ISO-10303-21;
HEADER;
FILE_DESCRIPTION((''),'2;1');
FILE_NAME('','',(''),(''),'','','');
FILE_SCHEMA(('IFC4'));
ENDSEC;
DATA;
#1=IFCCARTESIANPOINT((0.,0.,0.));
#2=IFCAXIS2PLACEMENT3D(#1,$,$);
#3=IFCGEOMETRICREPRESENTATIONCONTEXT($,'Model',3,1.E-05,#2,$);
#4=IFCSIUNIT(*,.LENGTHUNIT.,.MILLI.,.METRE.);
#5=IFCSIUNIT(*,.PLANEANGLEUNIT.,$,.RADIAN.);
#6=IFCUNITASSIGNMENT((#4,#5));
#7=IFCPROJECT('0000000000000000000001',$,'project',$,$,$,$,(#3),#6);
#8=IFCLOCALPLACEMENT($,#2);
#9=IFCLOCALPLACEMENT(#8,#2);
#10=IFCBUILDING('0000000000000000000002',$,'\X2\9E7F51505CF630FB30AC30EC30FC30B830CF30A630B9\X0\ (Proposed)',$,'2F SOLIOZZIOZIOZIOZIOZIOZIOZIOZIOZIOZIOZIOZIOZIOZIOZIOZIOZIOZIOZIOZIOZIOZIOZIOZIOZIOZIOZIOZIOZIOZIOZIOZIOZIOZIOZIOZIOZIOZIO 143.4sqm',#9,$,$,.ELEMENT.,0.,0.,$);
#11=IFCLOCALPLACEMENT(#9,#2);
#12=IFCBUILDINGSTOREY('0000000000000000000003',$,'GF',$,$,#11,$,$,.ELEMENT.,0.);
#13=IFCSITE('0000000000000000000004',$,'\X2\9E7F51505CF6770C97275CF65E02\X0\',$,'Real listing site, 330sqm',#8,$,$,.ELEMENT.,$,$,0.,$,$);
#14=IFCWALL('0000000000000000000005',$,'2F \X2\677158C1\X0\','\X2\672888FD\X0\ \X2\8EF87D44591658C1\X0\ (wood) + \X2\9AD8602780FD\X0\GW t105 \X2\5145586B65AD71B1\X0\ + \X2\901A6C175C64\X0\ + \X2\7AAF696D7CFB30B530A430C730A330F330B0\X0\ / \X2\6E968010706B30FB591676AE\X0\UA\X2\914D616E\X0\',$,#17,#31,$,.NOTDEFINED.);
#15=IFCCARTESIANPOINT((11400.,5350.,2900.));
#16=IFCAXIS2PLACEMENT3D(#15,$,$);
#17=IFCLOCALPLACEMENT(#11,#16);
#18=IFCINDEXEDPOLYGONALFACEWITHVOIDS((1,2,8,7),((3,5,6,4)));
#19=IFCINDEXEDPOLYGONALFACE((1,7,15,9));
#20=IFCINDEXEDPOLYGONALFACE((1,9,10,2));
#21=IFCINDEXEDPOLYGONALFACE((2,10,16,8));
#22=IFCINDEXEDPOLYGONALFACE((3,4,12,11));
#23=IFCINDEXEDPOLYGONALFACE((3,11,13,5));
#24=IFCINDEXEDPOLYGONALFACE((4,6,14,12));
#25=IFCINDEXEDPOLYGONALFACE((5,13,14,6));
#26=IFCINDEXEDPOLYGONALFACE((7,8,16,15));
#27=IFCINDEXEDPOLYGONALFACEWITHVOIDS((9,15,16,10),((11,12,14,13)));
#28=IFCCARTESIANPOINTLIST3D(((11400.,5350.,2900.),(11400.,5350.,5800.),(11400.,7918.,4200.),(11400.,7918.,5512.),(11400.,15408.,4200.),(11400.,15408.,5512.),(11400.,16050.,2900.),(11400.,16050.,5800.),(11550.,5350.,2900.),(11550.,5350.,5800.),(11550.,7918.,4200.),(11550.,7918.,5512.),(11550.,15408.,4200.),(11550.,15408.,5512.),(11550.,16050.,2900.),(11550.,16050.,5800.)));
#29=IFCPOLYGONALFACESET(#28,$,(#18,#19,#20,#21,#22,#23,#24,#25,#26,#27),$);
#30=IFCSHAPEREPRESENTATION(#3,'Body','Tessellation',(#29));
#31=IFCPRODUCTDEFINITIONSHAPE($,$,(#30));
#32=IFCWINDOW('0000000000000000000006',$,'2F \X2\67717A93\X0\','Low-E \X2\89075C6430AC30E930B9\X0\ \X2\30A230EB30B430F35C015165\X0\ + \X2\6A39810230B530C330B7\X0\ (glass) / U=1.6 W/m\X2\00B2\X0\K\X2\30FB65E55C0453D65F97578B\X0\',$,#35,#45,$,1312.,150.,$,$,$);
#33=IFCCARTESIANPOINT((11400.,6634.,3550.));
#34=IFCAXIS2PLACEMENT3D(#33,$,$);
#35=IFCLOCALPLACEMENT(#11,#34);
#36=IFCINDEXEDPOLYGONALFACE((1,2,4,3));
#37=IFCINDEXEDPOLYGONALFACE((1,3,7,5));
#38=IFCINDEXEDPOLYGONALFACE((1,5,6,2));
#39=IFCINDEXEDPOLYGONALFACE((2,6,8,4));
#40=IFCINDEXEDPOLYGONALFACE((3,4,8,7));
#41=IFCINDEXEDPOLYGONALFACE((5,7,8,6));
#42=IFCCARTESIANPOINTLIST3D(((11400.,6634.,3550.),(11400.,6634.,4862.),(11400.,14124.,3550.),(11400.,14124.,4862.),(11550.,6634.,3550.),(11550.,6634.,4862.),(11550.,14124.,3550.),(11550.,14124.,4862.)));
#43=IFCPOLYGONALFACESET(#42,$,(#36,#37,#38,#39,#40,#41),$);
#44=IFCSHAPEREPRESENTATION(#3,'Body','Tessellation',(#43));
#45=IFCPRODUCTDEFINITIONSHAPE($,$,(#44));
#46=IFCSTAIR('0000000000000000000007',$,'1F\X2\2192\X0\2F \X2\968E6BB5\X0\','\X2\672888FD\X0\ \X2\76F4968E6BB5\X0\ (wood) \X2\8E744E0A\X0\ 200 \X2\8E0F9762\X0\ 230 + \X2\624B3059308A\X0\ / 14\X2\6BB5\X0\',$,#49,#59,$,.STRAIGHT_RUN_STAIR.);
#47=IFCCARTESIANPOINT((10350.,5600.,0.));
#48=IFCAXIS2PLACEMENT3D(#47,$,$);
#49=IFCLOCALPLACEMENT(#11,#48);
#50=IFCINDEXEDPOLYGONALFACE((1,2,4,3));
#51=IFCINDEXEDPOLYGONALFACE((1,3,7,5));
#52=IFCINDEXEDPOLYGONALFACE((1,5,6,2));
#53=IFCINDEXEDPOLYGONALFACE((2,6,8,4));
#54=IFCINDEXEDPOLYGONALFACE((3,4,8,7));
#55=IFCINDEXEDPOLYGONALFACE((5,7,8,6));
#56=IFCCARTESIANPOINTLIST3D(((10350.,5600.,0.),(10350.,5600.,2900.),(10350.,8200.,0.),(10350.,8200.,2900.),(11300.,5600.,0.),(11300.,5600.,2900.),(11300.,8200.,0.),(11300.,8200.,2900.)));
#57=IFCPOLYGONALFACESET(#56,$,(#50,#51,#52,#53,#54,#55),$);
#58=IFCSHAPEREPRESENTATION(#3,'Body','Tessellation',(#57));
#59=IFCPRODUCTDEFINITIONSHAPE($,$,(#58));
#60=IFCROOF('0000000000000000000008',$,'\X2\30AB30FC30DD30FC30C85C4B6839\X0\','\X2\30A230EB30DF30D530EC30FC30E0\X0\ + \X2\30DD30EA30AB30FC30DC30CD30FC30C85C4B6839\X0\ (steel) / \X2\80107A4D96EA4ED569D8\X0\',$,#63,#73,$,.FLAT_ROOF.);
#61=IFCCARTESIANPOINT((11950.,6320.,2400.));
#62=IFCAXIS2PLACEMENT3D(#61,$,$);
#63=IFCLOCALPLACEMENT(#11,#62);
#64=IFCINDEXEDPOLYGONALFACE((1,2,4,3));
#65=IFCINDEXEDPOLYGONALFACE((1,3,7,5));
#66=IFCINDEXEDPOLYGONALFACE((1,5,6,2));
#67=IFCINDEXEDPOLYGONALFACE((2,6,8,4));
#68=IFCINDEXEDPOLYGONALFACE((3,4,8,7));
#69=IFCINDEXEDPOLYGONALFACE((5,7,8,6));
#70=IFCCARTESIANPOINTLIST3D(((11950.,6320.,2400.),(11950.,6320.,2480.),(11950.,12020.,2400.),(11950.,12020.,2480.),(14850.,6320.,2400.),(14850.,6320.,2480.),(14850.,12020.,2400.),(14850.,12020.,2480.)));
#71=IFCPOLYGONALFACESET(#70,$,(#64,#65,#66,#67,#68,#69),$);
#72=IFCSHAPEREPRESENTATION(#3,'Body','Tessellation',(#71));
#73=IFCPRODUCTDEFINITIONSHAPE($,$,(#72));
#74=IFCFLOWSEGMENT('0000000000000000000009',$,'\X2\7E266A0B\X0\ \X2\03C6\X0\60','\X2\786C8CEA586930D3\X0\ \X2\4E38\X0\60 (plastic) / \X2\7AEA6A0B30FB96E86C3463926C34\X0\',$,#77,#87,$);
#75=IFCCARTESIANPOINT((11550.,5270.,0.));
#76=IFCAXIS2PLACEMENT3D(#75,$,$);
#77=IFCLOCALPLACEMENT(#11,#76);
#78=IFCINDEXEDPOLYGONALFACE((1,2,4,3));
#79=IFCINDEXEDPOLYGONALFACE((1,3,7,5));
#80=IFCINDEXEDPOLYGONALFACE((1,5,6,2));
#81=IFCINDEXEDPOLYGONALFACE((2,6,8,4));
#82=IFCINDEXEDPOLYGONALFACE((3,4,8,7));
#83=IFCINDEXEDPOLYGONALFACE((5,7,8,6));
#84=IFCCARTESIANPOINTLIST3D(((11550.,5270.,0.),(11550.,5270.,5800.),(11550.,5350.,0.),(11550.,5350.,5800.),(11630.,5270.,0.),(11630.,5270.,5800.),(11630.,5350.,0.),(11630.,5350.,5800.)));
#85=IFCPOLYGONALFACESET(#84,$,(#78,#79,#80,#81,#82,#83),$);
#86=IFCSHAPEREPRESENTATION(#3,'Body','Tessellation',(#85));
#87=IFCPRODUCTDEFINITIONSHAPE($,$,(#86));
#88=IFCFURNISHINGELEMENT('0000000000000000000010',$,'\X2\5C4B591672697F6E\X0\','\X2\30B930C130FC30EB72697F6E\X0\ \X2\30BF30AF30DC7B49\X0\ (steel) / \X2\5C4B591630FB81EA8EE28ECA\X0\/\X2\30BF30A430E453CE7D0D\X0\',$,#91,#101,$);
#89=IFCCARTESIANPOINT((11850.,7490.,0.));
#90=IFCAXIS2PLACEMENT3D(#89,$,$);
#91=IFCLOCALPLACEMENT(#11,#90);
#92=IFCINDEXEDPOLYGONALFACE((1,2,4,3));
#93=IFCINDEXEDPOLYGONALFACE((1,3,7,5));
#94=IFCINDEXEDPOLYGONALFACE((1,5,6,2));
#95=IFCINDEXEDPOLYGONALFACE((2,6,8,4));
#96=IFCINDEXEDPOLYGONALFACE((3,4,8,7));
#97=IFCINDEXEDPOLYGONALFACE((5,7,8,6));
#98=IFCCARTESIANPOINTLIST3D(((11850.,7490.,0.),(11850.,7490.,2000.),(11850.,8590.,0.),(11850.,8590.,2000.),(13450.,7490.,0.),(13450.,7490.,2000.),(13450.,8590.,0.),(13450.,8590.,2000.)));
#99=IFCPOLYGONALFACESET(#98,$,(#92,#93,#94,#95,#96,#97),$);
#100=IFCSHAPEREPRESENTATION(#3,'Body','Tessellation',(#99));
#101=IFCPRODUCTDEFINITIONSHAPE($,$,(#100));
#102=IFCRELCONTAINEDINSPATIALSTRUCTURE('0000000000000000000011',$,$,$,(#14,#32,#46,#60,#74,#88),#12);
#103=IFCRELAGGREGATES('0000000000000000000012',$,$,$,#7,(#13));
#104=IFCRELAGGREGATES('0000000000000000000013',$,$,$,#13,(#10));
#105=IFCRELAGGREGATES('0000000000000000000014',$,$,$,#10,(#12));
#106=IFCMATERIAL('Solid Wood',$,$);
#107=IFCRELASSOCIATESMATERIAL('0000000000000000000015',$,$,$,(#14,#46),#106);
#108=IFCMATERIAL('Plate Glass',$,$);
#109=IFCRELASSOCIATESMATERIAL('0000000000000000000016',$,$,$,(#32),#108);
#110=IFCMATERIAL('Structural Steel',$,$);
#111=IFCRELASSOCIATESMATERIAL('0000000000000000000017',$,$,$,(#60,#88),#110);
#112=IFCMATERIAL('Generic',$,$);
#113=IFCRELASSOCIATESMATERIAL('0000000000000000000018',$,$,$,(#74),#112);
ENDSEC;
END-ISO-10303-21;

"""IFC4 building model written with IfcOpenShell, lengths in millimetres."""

from ifc_helpers import new_model, si_unit, frame, frame_2d, origin, place, context, project, spatial, rectangle, extrude, material, element, fill, save


model = new_model("IFC4")

# Units and contexts
model_context = context("Model", 3, precision=1e-05, world=origin())
ifc_project = project(units=[si_unit("LENGTHUNIT", "METRE", prefix="MILLI"), si_unit("PLANEANGLEUNIT", "RADIAN")], contexts=[model_context])

# Site, building, storey
site_placement = place(None, origin())
site = spatial("IfcSite", under=ifc_project, at=site_placement, Name="鹿児島県霧島市", ObjectType="Real listing site, 330sqm", CompositionType="ELEMENT", RefElevation=0.0)
building_placement = place(site_placement, origin())
building = spatial("IfcBuilding", under=site, at=building_placement, Name="鹿児島・ガレージハウス (Proposed)", ObjectType="2F SOLIOZZIOZIOZIOZIOZIOZIOZIOZIOZIOZIOZIOZIOZIOZIOZIOZIOZIOZIOZIOZIOZIOZIOZIOZIOZIOZIOZIOZIOZIOZIOZIOZIOZIOZIOZIOZIOZIOZIO 143.4sqm", CompositionType="ELEMENT", ElevationOfRefHeight=0.0, ElevationOfTerrain=0.0)
storey_placement = place(building_placement, origin())
storey = spatial("IfcBuildingStorey", under=building, at=storey_placement, Name="GF", CompositionType="ELEMENT", Elevation=0.0)

# Shared definitions
ifc_material_1 = material(Name="Solid Wood")
ifc_material_2 = material(Name="Structural Steel")

# Wall, opening, window
ifc_material_3 = material(Name="Plate Glass")
wall_1_placement = place(storey_placement, frame((11400.0, 5350.0, 2900.0)))
wall_1 = element("IfcWall", 1, at=wall_1_placement, inside=storey, material=ifc_material_1, Name="2F 東壁", Description="木製 軸組外壁 (wood) + 高性能GW t105 充填断熱 + 通気層 + 窯業系サイディング / 準耐火・外皮UA配慮", PredefinedType="NOTDEFINED", context=model_context, shape_type="SweptSolid", body=[
    extrude(rectangle(XDim=150.0, YDim=10700.0, at=frame_2d((75.0, 5350.0))), frame((11400.0, 5350.0, 2900.0)), (0.0, 0.0, 1.0), 2900.0),
])
opening_1_placement = place(storey_placement, frame((11400.0, 6634.0, 3550.0)))
opening_1 = element("IfcOpeningElement", 2, at=opening_1_placement, cuts=wall_1, PredefinedType="NOTDEFINED", context=model_context, shape_type="SweptSolid", body=[
    extrude(rectangle(XDim=150.0, YDim=7490.0, at=frame_2d((75.0, 3745.0))), frame((11400.0, 6634.0, 3550.0)), (0.0, 0.0, 1.0), 1312.0),
])
window_1_placement = place(storey_placement, frame((11400.0, 6634.0, 3550.0)))
window_1 = element("IfcWindow", 3, at=window_1_placement, inside=storey, material=ifc_material_3, Name="2F 東窓", Description="Low-E 複層ガラス アルゴン封入 + 樹脂サッシ (glass) / U=1.6 W/m²K・日射取得型", OverallHeight=1312.0, OverallWidth=150.0, context=model_context, shape_type="SweptSolid", body=[
    extrude(rectangle(XDim=150.0, YDim=7490.0, at=frame_2d((75.0, 3745.0))), frame((11400.0, 6634.0, 3550.0)), (0.0, 0.0, 1.0), 1312.0),
])
fill(opening_1, window_1)

# Stair
stair_placement = place(storey_placement, frame((10350.0, 5600.0, 0.0)))
element("IfcStair", 4, at=stair_placement, inside=storey, material=ifc_material_1, Name="1F→2F 階段", Description="木製 直階段 (wood) 蹴上 200 踏面 230 + 手すり / 14段", PredefinedType="STRAIGHT_RUN_STAIR", context=model_context, shape_type="SweptSolid", body=[
    extrude(rectangle(XDim=950.0, YDim=2600.0, at=frame_2d((475.0, 1300.0))), frame((10350.0, 5600.0, 0.0)), (0.0, 0.0, 1.0), 2900.0),
])

# Roof
roof_placement = place(storey_placement, frame((11950.0, 6320.0, 2400.0)))
element("IfcRoof", 5, at=roof_placement, inside=storey, material=ifc_material_2, Name="カーポート屋根", Description="アルミフレーム + ポリカーボネート屋根 (steel) / 耐積雪仕様", PredefinedType="FLAT_ROOF", context=model_context, shape_type="SweptSolid", body=[
    extrude(rectangle(XDim=2900.0, YDim=5700.0, at=frame_2d((1450.0, 2850.0))), frame((11950.0, 6320.0, 2400.0)), (0.0, 0.0, 1.0), 80.0),
])

# Flow segment
ifc_material_4 = material(Name="Generic")
flow_segment_placement = place(storey_placement, frame((11550.0, 5270.0, 0.0)))
element("IfcFlowSegment", 6, at=flow_segment_placement, inside=storey, material=ifc_material_4, Name="縦樋 φ60", Description="硬質塩ビ 丸60 (plastic) / 竪樋・雨水排水", context=model_context, shape_type="SweptSolid", body=[
    extrude(rectangle(XDim=80.0, YDim=80.0, at=frame_2d((40.0, 40.0))), frame((11550.0, 5270.0, 0.0)), (0.0, 0.0, 1.0), 5800.0),
])

# Furnishing element
furnishing_placement = place(storey_placement, frame((11850.0, 7490.0, 0.0)))
element("IfcFurnishingElement", 7, at=furnishing_placement, inside=storey, material=ifc_material_2, Name="屋外物置", Description="スチール物置 タクボ等 (steel) / 屋外・自転車/タイヤ収納", context=model_context, shape_type="SweptSolid", body=[
    extrude(rectangle(XDim=1600.0, YDim=1100.0, at=frame_2d((800.0, 550.0))), frame((11850.0, 7490.0, 0.0)), (0.0, 0.0, 1.0), 2000.0),
])

save(model, "model.ifc")
